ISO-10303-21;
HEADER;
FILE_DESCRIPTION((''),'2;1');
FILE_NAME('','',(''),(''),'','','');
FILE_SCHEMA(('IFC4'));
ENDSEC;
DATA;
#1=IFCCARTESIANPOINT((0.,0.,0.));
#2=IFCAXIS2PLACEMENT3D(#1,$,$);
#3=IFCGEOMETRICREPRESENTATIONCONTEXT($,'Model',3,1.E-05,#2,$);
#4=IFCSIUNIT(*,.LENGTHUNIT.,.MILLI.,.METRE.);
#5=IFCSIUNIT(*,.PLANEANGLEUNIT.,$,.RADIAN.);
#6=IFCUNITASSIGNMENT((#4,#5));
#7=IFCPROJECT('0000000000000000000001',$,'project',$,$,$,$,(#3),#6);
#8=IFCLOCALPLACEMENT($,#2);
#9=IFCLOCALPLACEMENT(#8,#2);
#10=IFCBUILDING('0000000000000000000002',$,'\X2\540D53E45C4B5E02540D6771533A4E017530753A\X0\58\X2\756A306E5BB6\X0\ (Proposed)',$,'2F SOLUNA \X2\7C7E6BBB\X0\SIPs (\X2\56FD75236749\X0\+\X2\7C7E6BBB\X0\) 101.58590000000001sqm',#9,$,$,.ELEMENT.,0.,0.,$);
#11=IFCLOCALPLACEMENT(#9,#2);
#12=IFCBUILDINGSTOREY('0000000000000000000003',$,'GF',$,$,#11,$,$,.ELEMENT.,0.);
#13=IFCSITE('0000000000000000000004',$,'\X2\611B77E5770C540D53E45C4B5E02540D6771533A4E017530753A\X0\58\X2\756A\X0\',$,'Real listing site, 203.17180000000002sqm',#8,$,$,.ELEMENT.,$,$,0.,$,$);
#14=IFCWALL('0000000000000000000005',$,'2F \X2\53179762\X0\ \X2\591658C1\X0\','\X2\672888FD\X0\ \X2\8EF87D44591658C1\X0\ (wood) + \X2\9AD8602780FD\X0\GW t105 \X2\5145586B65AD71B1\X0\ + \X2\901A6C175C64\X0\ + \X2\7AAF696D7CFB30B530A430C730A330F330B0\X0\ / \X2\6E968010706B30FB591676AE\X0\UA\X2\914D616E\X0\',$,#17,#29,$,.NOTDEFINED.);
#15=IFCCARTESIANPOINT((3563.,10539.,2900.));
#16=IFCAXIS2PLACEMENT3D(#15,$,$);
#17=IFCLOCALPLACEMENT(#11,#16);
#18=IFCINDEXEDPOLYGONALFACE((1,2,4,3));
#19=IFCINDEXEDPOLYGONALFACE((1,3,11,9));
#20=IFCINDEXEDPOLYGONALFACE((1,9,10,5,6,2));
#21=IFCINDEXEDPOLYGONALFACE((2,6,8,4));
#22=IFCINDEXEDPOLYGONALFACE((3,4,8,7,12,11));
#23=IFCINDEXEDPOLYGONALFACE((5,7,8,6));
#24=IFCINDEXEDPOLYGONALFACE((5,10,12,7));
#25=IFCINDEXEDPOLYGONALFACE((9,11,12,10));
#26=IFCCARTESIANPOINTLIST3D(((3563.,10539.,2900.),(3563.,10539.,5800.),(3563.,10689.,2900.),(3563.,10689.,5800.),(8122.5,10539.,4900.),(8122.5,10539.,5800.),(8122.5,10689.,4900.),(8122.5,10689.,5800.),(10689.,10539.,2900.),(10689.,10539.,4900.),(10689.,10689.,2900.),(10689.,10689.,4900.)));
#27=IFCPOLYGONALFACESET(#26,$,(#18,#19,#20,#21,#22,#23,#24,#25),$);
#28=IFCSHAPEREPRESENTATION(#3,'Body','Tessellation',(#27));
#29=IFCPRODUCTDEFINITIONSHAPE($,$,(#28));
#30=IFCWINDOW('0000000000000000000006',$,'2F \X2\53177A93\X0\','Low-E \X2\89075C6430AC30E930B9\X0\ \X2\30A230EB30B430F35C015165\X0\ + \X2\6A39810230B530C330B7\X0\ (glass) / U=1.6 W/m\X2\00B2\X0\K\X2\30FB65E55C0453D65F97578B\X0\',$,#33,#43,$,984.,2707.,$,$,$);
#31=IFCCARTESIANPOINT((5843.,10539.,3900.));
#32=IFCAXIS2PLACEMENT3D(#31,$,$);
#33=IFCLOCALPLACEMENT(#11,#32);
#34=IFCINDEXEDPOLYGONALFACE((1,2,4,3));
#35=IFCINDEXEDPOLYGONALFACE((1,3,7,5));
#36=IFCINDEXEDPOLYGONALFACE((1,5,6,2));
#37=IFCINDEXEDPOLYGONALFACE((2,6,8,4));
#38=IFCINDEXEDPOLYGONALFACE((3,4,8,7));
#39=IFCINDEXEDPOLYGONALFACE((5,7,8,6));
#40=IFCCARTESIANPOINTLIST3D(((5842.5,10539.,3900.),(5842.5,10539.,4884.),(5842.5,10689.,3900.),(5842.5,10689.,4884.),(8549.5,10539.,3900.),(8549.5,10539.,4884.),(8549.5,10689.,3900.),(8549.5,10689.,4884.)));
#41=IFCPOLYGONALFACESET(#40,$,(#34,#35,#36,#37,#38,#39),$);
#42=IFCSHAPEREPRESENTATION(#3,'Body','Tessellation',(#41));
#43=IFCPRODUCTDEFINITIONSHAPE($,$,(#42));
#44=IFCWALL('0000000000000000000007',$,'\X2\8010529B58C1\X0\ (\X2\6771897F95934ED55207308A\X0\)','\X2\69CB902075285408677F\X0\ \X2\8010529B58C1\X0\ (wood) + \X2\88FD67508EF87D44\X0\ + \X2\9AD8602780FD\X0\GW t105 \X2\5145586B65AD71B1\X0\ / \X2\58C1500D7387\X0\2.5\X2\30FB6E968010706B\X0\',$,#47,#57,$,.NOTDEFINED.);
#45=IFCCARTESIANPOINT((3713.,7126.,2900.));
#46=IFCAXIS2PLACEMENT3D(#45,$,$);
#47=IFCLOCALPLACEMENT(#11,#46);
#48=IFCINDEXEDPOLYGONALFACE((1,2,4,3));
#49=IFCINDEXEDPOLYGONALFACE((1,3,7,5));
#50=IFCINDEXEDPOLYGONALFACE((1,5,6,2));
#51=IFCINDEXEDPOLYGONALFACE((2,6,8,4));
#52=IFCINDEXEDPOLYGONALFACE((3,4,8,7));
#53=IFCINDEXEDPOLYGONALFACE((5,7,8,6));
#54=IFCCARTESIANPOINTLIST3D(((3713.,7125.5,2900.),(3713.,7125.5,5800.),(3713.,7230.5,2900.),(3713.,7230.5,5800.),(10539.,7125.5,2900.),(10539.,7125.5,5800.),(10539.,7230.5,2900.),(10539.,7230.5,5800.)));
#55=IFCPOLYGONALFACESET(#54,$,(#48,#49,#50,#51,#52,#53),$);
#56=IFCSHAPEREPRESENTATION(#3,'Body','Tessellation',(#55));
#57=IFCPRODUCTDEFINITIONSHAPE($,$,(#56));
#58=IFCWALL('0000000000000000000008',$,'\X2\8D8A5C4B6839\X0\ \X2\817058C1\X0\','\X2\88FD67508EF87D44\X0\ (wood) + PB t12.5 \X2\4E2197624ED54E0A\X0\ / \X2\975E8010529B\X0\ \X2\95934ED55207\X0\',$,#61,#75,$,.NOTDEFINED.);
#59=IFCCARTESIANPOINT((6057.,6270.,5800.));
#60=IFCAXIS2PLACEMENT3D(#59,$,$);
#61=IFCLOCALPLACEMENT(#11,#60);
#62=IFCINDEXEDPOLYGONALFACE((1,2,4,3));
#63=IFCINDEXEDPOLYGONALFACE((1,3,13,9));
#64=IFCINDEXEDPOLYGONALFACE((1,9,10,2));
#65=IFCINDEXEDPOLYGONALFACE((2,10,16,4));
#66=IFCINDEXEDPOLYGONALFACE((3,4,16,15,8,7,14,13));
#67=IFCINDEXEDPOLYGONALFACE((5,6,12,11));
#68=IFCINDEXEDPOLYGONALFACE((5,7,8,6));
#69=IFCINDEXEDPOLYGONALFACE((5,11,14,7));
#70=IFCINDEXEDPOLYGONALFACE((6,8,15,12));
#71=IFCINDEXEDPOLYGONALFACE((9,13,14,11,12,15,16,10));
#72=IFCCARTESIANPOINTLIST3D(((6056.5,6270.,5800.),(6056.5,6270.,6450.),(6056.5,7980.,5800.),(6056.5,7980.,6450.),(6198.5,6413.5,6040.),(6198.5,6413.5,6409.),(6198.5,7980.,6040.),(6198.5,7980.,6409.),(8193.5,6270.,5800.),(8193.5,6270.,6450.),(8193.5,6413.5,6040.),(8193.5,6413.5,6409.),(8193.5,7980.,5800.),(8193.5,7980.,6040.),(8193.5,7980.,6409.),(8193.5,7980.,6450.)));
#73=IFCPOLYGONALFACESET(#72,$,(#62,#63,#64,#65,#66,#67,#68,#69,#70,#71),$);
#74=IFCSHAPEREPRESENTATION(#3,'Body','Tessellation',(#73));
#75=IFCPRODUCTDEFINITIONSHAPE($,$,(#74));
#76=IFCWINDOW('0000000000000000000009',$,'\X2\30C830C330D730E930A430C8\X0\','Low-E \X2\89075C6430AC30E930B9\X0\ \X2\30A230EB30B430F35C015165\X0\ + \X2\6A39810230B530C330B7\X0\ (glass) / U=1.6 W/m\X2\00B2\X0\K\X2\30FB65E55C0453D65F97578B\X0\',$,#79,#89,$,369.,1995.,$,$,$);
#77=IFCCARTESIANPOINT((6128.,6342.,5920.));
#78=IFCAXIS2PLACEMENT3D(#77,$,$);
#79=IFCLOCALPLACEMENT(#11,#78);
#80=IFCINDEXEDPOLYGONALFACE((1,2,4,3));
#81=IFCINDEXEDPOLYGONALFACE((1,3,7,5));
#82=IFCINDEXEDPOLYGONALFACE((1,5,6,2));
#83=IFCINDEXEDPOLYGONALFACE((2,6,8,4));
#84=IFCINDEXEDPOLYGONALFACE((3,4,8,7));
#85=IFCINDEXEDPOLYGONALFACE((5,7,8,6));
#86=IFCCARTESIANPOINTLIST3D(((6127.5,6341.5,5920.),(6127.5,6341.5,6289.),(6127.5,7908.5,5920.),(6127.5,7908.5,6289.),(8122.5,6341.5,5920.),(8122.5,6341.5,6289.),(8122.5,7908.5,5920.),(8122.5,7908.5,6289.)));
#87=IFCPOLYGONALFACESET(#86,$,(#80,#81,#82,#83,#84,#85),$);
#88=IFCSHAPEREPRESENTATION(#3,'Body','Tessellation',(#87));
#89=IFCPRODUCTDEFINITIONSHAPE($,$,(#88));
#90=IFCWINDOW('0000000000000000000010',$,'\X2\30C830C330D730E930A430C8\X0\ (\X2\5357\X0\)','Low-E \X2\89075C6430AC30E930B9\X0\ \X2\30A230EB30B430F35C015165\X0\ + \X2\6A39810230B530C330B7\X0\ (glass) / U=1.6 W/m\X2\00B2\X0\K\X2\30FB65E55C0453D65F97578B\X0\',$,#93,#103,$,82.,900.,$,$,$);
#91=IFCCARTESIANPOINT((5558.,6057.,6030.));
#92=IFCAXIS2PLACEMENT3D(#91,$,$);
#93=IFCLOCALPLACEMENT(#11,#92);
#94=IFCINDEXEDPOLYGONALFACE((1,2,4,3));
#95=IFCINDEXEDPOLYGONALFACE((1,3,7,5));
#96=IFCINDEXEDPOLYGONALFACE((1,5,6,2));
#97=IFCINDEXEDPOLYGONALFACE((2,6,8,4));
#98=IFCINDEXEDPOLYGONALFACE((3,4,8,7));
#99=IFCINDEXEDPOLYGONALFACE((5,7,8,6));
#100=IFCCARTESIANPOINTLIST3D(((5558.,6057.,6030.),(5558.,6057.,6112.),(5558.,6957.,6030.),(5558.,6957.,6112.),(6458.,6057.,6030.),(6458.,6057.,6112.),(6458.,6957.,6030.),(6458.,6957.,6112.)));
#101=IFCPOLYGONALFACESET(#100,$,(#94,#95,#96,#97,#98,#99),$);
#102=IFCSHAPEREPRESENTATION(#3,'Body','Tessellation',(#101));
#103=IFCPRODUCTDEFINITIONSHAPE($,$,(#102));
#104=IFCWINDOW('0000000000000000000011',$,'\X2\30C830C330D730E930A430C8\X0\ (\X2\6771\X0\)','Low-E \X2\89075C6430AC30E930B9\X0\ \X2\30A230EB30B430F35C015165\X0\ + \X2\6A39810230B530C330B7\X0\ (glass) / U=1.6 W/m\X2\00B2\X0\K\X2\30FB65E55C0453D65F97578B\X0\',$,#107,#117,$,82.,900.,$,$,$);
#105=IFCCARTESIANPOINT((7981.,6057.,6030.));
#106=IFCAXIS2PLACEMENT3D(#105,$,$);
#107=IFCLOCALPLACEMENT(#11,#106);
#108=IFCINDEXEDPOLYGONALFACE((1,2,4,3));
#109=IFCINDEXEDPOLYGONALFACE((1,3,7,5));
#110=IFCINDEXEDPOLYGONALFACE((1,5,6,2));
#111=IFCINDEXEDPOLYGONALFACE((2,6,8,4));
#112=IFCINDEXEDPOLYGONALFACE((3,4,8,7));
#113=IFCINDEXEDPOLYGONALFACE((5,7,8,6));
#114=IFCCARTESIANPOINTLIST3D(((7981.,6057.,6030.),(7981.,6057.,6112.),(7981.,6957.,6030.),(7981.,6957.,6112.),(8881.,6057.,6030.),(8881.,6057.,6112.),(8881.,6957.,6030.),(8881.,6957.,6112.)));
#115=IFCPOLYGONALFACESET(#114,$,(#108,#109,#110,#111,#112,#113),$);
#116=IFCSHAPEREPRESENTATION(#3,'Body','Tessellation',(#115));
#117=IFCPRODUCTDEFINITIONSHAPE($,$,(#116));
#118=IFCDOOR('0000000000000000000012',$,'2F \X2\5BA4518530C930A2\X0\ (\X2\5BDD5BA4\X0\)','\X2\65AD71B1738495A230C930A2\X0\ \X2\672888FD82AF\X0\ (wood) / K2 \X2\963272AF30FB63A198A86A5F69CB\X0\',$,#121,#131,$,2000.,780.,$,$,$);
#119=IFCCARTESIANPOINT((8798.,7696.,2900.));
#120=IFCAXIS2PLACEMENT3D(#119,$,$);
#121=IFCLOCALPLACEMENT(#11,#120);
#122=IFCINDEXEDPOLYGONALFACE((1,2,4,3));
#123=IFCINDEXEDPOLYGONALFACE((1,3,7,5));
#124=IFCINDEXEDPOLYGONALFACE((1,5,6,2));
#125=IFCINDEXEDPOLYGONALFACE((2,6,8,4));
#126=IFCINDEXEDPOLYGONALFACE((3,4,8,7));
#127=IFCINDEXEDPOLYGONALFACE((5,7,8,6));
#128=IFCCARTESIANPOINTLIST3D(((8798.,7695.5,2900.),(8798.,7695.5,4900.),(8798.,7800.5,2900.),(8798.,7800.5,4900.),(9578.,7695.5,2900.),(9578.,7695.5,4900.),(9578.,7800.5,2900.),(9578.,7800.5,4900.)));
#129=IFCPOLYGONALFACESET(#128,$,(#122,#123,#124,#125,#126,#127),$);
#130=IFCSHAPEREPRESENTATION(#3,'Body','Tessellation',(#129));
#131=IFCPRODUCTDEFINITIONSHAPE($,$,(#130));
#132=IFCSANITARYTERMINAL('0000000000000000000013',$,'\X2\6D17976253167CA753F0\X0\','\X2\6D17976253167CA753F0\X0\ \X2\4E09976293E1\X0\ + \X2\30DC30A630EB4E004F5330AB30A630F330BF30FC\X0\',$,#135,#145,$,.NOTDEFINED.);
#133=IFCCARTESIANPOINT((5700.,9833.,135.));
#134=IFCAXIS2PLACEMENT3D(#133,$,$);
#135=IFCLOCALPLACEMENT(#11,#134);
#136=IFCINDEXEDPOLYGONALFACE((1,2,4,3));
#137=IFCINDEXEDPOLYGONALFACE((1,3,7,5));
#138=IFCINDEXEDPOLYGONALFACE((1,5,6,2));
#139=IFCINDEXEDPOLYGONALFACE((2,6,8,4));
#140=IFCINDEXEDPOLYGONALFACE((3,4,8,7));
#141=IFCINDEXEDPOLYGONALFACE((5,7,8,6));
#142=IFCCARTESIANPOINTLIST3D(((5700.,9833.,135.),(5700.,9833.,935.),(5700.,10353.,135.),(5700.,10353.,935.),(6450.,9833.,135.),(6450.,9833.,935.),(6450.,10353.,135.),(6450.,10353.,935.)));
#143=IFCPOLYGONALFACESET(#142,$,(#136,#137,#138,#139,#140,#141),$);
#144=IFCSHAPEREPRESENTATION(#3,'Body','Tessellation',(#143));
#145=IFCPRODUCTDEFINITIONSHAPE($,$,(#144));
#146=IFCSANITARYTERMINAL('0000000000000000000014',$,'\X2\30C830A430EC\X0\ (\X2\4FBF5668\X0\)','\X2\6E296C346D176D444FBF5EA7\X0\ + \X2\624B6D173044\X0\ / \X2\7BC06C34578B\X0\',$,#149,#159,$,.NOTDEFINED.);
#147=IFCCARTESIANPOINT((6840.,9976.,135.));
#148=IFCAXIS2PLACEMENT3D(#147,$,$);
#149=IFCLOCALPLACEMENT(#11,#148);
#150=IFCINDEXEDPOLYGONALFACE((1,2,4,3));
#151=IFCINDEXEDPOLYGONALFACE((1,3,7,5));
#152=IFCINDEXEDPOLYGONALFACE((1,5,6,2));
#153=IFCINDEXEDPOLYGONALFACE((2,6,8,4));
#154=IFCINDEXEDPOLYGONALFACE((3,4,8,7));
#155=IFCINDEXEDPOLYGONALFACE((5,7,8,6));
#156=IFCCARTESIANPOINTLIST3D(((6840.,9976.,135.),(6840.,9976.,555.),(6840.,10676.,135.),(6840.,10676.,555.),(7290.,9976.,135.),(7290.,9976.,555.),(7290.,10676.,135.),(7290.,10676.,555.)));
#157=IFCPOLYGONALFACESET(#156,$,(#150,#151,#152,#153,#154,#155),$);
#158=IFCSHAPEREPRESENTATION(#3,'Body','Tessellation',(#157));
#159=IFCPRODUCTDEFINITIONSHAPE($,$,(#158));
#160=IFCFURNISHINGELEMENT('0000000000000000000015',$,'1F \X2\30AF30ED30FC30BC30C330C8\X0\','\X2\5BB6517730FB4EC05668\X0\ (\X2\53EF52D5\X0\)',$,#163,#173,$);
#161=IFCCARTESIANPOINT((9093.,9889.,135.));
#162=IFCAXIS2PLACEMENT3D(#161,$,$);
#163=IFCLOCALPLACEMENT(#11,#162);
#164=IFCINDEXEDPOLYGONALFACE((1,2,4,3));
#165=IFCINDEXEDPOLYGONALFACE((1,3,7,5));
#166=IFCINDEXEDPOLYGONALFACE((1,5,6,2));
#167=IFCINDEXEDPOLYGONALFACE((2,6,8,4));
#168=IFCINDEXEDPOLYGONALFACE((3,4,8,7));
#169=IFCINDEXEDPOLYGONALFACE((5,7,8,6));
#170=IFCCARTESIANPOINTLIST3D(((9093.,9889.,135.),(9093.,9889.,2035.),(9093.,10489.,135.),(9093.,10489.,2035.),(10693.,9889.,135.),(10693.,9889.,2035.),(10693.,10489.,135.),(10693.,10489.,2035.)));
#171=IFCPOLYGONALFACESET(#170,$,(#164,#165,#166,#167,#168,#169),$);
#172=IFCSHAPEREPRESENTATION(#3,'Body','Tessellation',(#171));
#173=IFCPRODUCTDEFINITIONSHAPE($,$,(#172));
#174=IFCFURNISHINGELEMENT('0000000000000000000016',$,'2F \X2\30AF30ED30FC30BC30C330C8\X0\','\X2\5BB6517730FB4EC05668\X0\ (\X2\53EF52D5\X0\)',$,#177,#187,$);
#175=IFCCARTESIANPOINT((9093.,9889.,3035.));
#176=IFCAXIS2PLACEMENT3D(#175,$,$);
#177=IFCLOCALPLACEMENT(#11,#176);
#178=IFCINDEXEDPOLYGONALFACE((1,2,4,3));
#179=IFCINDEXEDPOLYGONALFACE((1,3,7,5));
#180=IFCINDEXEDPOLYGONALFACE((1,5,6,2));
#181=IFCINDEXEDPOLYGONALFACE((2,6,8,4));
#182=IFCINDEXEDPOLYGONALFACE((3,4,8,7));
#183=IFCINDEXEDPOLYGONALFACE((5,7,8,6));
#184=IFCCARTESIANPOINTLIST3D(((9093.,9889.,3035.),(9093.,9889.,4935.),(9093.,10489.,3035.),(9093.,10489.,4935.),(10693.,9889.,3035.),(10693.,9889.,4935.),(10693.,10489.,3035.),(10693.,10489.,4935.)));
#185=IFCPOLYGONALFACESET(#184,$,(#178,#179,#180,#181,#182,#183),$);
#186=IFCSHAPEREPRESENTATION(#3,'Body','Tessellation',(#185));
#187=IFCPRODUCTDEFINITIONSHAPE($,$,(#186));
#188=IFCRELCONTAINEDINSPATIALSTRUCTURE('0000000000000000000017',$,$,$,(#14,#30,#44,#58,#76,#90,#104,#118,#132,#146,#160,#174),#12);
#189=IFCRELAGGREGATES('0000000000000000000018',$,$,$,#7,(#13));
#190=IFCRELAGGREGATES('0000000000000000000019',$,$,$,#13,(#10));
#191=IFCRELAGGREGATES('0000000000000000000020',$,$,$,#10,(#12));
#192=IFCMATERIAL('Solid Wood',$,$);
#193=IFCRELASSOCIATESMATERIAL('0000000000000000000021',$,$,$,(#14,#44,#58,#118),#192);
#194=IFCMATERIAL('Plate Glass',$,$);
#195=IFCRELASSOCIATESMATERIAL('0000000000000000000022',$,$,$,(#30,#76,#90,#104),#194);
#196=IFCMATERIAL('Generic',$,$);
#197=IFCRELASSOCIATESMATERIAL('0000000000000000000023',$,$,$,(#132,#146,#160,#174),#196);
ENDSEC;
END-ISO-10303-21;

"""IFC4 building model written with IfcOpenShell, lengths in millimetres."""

from ifc_helpers import new_model, si_unit, frame, frame_2d, origin, place, context, project, spatial, rectangle, extrude, material, element, fill, save


model = new_model("IFC4")

# Units and contexts
model_context = context("Model", 3, precision=1e-05, world=origin())
ifc_project = project(units=[si_unit("LENGTHUNIT", "METRE", prefix="MILLI"), si_unit("PLANEANGLEUNIT", "RADIAN")], contexts=[model_context])

# Site, building, storey
site_placement = place(None, origin())
site = spatial("IfcSite", under=ifc_project, at=site_placement, Name="愛知県名古屋市名東区丁田町58番", ObjectType="Real listing site, 203.17180000000002sqm", CompositionType="ELEMENT", RefElevation=0.0)
building_placement = place(site_placement, origin())
building = spatial("IfcBuilding", under=site, at=building_placement, Name="名古屋市名東区丁田町58番の家 (Proposed)", ObjectType="2F SOLUNA 籾殻SIPs (国産杉+籾殻) 101.58590000000001sqm", CompositionType="ELEMENT", ElevationOfRefHeight=0.0, ElevationOfTerrain=0.0)
storey_placement = place(building_placement, origin())
storey = spatial("IfcBuildingStorey", under=building, at=storey_placement, Name="GF", CompositionType="ELEMENT", Elevation=0.0)

# Wall, opening, window
ifc_material_1 = material(Name="Solid Wood")
wall_1_placement = place(storey_placement, frame((3563.0, 10539.0, 2900.0)))
wall_1 = element("IfcWall", 1, at=wall_1_placement, inside=storey, material=ifc_material_1, Name="2F 北面 外壁", Description="木製 軸組外壁 (wood) + 高性能GW t105 充填断熱 + 通気層 + 窯業系サイディング / 準耐火・外皮UA配慮", PredefinedType="NOTDEFINED", context=model_context, shape_type="SweptSolid", body=[
    extrude(rectangle(XDim=7126.0, YDim=150.0, at=frame_2d((3563.0, 75.0))), frame((3563.0, 10539.0, 2900.0)), (0.0, 0.0, 1.0), 2900.0),
])
opening_1_placement = place(storey_placement, frame((5843.0, 10539.0, 3900.0)))
opening_1 = element("IfcOpeningElement", 2, at=opening_1_placement, cuts=wall_1, PredefinedType="NOTDEFINED", context=model_context, shape_type="SweptSolid", body=[
    extrude(rectangle(XDim=2707.0, YDim=150.0, at=frame_2d((1353.0, 75.0))), frame((5843.0, 10539.0, 3900.0)), (0.0, 0.0, 1.0), 984.0),
])
ifc_material_2 = material(Name="Plate Glass")
window_1_placement = place(storey_placement, frame((5843.0, 10539.0, 3900.0)))
window_1 = element("IfcWindow", 3, at=window_1_placement, inside=storey, material=ifc_material_2, Name="2F 北窓", Description="Low-E 複層ガラス アルゴン封入 + 樹脂サッシ (glass) / U=1.6 W/m²K・日射取得型", OverallHeight=984.0, OverallWidth=2707.0, context=model_context, shape_type="SweptSolid", body=[
    extrude(rectangle(XDim=2707.0, YDim=150.0, at=frame_2d((1353.0, 75.0))), frame((5843.0, 10539.0, 3900.0)), (0.0, 0.0, 1.0), 984.0),
])
fill(opening_1, window_1)

# Wall
wall_2_placement = place(storey_placement, frame((3713.0, 7126.0, 2900.0)))
element("IfcWall", 4, at=wall_2_placement, inside=storey, material=ifc_material_1, Name="耐力壁 (東西間仕切り)", Description="構造用合板 耐力壁 (wood) + 製材軸組 + 高性能GW t105 充填断熱 / 壁倍率2.5・準耐火", PredefinedType="NOTDEFINED", context=model_context, shape_type="SweptSolid", body=[
    extrude(rectangle(XDim=6826.0, YDim=105.0, at=frame_2d((3413.0, 52.0))), frame((3713.0, 7126.0, 2900.0)), (0.0, 0.0, 1.0), 2900.0),
])

# Wall, openings, windows
wall_3_placement = place(storey_placement, frame((6057.0, 6270.0, 5800.0)))
wall_3 = element("IfcWall", 5, at=wall_3_placement, inside=storey, material=ifc_material_1, Name="越屋根 腰壁", Description="製材軸組 (wood) + PB t12.5 両面仕上 / 非耐力 間仕切", PredefinedType="NOTDEFINED", context=model_context, shape_type="SweptSolid", body=[
    extrude(rectangle(XDim=2137.0, YDim=1710.0, at=frame_2d((1068.0, 855.0))), frame((6057.0, 6270.0, 5800.0)), (0.0, 0.0, 1.0), 650.0),
])
opening_2_placement = place(storey_placement, frame((6128.0, 6342.0, 5920.0)))
opening_2 = element("IfcOpeningElement", 6, at=opening_2_placement, cuts=wall_3, PredefinedType="NOTDEFINED", context=model_context, shape_type="SweptSolid", body=[
    extrude(rectangle(XDim=1995.0, YDim=1567.0, at=frame_2d((997.0, 783.0))), frame((6128.0, 6342.0, 5920.0)), (0.0, 0.0, 1.0), 369.0),
])
opening_3_placement = place(storey_placement, frame((5558.0, 6057.0, 6030.0)))
opening_3 = element("IfcOpeningElement", 7, at=opening_3_placement, cuts=wall_3, PredefinedType="NOTDEFINED", context=model_context, shape_type="SweptSolid", body=[
    extrude(rectangle(XDim=900.0, YDim=900.0, at=frame_2d((450.0, 450.0))), frame((5558.0, 6057.0, 6030.0)), (0.0, 0.0, 1.0), 82.0),
])
opening_4_placement = place(storey_placement, frame((7981.0, 6057.0, 6030.0)))
opening_4 = element("IfcOpeningElement", 8, at=opening_4_placement, cuts=wall_3, PredefinedType="NOTDEFINED", context=model_context, shape_type="SweptSolid", body=[
    extrude(rectangle(XDim=900.0, YDim=900.0, at=frame_2d((450.0, 450.0))), frame((7981.0, 6057.0, 6030.0)), (0.0, 0.0, 1.0), 82.0),
])
window_2_placement = place(storey_placement, frame((6128.0, 6342.0, 5920.0)))
window_2 = element("IfcWindow", 9, at=window_2_placement, inside=storey, material=ifc_material_2, Name="トップライト", Description="Low-E 複層ガラス アルゴン封入 + 樹脂サッシ (glass) / U=1.6 W/m²K・日射取得型", OverallHeight=369.0, OverallWidth=1995.0, context=model_context, shape_type="SweptSolid", body=[
    extrude(rectangle(XDim=1995.0, YDim=1567.0, at=frame_2d((997.0, 783.0))), frame((6128.0, 6342.0, 5920.0)), (0.0, 0.0, 1.0), 369.0),
])
fill(opening_2, window_2)
window_3_placement = place(storey_placement, frame((5558.0, 6057.0, 6030.0)))
window_3 = element("IfcWindow", 10, at=window_3_placement, inside=storey, material=ifc_material_2, Name="トップライト (南)", Description="Low-E 複層ガラス アルゴン封入 + 樹脂サッシ (glass) / U=1.6 W/m²K・日射取得型", OverallHeight=82.0, OverallWidth=900.0, context=model_context, shape_type="SweptSolid", body=[
    extrude(rectangle(XDim=900.0, YDim=900.0, at=frame_2d((450.0, 450.0))), frame((5558.0, 6057.0, 6030.0)), (0.0, 0.0, 1.0), 82.0),
])
fill(opening_3, window_3)
window_4_placement = place(storey_placement, frame((7981.0, 6057.0, 6030.0)))
window_4 = element("IfcWindow", 11, at=window_4_placement, inside=storey, material=ifc_material_2, Name="トップライト (東)", Description="Low-E 複層ガラス アルゴン封入 + 樹脂サッシ (glass) / U=1.6 W/m²K・日射取得型", OverallHeight=82.0, OverallWidth=900.0, context=model_context, shape_type="SweptSolid", body=[
    extrude(rectangle(XDim=900.0, YDim=900.0, at=frame_2d((450.0, 450.0))), frame((7981.0, 6057.0, 6030.0)), (0.0, 0.0, 1.0), 82.0),
])
fill(opening_4, window_4)

# Door
door_placement = place(storey_placement, frame((8798.0, 7696.0, 2900.0)))
element("IfcDoor", 12, at=door_placement, inside=storey, material=ifc_material_1, Name="2F 室内ドア (寝室)", Description="断熱玄関ドア 木製芯 (wood) / K2 防犯・採風機構", OverallHeight=2000.0, OverallWidth=780.0, context=model_context, shape_type="SweptSolid", body=[
    extrude(rectangle(XDim=780.0, YDim=105.0, at=frame_2d((390.0, 52.0))), frame((8798.0, 7696.0, 2900.0)), (0.0, 0.0, 1.0), 2000.0),
])

# Sanitary terminals
ifc_material_3 = material(Name="Generic")
sanitary_terminal_1_placement = place(storey_placement, frame((5700.0, 9833.0, 135.0)))
element("IfcSanitaryTerminal", 13, at=sanitary_terminal_1_placement, inside=storey, material=ifc_material_3, Name="洗面化粧台", Description="洗面化粧台 三面鏡 + ボウル一体カウンター", PredefinedType="NOTDEFINED", context=model_context, shape_type="SweptSolid", body=[
    extrude(rectangle(XDim=750.0, YDim=520.0, at=frame_2d((375.0, 260.0))), frame((5700.0, 9833.0, 135.0)), (0.0, 0.0, 1.0), 800.0),
])
sanitary_terminal_2_placement = place(storey_placement, frame((6840.0, 9976.0, 135.0)))
element("IfcSanitaryTerminal", 14, at=sanitary_terminal_2_placement, inside=storey, material=ifc_material_3, Name="トイレ (便器)", Description="温水洗浄便座 + 手洗い / 節水型", PredefinedType="NOTDEFINED", context=model_context, shape_type="SweptSolid", body=[
    extrude(rectangle(XDim=450.0, YDim=700.0, at=frame_2d((225.0, 350.0))), frame((6840.0, 9976.0, 135.0)), (0.0, 0.0, 1.0), 420.0),
])

# Furnishing elements
furnishing_1_placement = place(storey_placement, frame((9093.0, 9889.0, 135.0)))
element("IfcFurnishingElement", 15, at=furnishing_1_placement, inside=storey, material=ifc_material_3, Name="1F クローゼット", Description="家具・什器 (可動)", context=model_context, shape_type="SweptSolid", body=[
    extrude(rectangle(XDim=1600.0, YDim=600.0, at=frame_2d((800.0, 300.0))), frame((9093.0, 9889.0, 135.0)), (0.0, 0.0, 1.0), 1900.0),
])
furnishing_2_placement = place(storey_placement, frame((9093.0, 9889.0, 3035.0)))
element("IfcFurnishingElement", 16, at=furnishing_2_placement, inside=storey, material=ifc_material_3, Name="2F クローゼット", Description="家具・什器 (可動)", context=model_context, shape_type="SweptSolid", body=[
    extrude(rectangle(XDim=1600.0, YDim=600.0, at=frame_2d((800.0, 300.0))), frame((9093.0, 9889.0, 3035.0)), (0.0, 0.0, 1.0), 1900.0),
])

save(model, "model.ifc")
